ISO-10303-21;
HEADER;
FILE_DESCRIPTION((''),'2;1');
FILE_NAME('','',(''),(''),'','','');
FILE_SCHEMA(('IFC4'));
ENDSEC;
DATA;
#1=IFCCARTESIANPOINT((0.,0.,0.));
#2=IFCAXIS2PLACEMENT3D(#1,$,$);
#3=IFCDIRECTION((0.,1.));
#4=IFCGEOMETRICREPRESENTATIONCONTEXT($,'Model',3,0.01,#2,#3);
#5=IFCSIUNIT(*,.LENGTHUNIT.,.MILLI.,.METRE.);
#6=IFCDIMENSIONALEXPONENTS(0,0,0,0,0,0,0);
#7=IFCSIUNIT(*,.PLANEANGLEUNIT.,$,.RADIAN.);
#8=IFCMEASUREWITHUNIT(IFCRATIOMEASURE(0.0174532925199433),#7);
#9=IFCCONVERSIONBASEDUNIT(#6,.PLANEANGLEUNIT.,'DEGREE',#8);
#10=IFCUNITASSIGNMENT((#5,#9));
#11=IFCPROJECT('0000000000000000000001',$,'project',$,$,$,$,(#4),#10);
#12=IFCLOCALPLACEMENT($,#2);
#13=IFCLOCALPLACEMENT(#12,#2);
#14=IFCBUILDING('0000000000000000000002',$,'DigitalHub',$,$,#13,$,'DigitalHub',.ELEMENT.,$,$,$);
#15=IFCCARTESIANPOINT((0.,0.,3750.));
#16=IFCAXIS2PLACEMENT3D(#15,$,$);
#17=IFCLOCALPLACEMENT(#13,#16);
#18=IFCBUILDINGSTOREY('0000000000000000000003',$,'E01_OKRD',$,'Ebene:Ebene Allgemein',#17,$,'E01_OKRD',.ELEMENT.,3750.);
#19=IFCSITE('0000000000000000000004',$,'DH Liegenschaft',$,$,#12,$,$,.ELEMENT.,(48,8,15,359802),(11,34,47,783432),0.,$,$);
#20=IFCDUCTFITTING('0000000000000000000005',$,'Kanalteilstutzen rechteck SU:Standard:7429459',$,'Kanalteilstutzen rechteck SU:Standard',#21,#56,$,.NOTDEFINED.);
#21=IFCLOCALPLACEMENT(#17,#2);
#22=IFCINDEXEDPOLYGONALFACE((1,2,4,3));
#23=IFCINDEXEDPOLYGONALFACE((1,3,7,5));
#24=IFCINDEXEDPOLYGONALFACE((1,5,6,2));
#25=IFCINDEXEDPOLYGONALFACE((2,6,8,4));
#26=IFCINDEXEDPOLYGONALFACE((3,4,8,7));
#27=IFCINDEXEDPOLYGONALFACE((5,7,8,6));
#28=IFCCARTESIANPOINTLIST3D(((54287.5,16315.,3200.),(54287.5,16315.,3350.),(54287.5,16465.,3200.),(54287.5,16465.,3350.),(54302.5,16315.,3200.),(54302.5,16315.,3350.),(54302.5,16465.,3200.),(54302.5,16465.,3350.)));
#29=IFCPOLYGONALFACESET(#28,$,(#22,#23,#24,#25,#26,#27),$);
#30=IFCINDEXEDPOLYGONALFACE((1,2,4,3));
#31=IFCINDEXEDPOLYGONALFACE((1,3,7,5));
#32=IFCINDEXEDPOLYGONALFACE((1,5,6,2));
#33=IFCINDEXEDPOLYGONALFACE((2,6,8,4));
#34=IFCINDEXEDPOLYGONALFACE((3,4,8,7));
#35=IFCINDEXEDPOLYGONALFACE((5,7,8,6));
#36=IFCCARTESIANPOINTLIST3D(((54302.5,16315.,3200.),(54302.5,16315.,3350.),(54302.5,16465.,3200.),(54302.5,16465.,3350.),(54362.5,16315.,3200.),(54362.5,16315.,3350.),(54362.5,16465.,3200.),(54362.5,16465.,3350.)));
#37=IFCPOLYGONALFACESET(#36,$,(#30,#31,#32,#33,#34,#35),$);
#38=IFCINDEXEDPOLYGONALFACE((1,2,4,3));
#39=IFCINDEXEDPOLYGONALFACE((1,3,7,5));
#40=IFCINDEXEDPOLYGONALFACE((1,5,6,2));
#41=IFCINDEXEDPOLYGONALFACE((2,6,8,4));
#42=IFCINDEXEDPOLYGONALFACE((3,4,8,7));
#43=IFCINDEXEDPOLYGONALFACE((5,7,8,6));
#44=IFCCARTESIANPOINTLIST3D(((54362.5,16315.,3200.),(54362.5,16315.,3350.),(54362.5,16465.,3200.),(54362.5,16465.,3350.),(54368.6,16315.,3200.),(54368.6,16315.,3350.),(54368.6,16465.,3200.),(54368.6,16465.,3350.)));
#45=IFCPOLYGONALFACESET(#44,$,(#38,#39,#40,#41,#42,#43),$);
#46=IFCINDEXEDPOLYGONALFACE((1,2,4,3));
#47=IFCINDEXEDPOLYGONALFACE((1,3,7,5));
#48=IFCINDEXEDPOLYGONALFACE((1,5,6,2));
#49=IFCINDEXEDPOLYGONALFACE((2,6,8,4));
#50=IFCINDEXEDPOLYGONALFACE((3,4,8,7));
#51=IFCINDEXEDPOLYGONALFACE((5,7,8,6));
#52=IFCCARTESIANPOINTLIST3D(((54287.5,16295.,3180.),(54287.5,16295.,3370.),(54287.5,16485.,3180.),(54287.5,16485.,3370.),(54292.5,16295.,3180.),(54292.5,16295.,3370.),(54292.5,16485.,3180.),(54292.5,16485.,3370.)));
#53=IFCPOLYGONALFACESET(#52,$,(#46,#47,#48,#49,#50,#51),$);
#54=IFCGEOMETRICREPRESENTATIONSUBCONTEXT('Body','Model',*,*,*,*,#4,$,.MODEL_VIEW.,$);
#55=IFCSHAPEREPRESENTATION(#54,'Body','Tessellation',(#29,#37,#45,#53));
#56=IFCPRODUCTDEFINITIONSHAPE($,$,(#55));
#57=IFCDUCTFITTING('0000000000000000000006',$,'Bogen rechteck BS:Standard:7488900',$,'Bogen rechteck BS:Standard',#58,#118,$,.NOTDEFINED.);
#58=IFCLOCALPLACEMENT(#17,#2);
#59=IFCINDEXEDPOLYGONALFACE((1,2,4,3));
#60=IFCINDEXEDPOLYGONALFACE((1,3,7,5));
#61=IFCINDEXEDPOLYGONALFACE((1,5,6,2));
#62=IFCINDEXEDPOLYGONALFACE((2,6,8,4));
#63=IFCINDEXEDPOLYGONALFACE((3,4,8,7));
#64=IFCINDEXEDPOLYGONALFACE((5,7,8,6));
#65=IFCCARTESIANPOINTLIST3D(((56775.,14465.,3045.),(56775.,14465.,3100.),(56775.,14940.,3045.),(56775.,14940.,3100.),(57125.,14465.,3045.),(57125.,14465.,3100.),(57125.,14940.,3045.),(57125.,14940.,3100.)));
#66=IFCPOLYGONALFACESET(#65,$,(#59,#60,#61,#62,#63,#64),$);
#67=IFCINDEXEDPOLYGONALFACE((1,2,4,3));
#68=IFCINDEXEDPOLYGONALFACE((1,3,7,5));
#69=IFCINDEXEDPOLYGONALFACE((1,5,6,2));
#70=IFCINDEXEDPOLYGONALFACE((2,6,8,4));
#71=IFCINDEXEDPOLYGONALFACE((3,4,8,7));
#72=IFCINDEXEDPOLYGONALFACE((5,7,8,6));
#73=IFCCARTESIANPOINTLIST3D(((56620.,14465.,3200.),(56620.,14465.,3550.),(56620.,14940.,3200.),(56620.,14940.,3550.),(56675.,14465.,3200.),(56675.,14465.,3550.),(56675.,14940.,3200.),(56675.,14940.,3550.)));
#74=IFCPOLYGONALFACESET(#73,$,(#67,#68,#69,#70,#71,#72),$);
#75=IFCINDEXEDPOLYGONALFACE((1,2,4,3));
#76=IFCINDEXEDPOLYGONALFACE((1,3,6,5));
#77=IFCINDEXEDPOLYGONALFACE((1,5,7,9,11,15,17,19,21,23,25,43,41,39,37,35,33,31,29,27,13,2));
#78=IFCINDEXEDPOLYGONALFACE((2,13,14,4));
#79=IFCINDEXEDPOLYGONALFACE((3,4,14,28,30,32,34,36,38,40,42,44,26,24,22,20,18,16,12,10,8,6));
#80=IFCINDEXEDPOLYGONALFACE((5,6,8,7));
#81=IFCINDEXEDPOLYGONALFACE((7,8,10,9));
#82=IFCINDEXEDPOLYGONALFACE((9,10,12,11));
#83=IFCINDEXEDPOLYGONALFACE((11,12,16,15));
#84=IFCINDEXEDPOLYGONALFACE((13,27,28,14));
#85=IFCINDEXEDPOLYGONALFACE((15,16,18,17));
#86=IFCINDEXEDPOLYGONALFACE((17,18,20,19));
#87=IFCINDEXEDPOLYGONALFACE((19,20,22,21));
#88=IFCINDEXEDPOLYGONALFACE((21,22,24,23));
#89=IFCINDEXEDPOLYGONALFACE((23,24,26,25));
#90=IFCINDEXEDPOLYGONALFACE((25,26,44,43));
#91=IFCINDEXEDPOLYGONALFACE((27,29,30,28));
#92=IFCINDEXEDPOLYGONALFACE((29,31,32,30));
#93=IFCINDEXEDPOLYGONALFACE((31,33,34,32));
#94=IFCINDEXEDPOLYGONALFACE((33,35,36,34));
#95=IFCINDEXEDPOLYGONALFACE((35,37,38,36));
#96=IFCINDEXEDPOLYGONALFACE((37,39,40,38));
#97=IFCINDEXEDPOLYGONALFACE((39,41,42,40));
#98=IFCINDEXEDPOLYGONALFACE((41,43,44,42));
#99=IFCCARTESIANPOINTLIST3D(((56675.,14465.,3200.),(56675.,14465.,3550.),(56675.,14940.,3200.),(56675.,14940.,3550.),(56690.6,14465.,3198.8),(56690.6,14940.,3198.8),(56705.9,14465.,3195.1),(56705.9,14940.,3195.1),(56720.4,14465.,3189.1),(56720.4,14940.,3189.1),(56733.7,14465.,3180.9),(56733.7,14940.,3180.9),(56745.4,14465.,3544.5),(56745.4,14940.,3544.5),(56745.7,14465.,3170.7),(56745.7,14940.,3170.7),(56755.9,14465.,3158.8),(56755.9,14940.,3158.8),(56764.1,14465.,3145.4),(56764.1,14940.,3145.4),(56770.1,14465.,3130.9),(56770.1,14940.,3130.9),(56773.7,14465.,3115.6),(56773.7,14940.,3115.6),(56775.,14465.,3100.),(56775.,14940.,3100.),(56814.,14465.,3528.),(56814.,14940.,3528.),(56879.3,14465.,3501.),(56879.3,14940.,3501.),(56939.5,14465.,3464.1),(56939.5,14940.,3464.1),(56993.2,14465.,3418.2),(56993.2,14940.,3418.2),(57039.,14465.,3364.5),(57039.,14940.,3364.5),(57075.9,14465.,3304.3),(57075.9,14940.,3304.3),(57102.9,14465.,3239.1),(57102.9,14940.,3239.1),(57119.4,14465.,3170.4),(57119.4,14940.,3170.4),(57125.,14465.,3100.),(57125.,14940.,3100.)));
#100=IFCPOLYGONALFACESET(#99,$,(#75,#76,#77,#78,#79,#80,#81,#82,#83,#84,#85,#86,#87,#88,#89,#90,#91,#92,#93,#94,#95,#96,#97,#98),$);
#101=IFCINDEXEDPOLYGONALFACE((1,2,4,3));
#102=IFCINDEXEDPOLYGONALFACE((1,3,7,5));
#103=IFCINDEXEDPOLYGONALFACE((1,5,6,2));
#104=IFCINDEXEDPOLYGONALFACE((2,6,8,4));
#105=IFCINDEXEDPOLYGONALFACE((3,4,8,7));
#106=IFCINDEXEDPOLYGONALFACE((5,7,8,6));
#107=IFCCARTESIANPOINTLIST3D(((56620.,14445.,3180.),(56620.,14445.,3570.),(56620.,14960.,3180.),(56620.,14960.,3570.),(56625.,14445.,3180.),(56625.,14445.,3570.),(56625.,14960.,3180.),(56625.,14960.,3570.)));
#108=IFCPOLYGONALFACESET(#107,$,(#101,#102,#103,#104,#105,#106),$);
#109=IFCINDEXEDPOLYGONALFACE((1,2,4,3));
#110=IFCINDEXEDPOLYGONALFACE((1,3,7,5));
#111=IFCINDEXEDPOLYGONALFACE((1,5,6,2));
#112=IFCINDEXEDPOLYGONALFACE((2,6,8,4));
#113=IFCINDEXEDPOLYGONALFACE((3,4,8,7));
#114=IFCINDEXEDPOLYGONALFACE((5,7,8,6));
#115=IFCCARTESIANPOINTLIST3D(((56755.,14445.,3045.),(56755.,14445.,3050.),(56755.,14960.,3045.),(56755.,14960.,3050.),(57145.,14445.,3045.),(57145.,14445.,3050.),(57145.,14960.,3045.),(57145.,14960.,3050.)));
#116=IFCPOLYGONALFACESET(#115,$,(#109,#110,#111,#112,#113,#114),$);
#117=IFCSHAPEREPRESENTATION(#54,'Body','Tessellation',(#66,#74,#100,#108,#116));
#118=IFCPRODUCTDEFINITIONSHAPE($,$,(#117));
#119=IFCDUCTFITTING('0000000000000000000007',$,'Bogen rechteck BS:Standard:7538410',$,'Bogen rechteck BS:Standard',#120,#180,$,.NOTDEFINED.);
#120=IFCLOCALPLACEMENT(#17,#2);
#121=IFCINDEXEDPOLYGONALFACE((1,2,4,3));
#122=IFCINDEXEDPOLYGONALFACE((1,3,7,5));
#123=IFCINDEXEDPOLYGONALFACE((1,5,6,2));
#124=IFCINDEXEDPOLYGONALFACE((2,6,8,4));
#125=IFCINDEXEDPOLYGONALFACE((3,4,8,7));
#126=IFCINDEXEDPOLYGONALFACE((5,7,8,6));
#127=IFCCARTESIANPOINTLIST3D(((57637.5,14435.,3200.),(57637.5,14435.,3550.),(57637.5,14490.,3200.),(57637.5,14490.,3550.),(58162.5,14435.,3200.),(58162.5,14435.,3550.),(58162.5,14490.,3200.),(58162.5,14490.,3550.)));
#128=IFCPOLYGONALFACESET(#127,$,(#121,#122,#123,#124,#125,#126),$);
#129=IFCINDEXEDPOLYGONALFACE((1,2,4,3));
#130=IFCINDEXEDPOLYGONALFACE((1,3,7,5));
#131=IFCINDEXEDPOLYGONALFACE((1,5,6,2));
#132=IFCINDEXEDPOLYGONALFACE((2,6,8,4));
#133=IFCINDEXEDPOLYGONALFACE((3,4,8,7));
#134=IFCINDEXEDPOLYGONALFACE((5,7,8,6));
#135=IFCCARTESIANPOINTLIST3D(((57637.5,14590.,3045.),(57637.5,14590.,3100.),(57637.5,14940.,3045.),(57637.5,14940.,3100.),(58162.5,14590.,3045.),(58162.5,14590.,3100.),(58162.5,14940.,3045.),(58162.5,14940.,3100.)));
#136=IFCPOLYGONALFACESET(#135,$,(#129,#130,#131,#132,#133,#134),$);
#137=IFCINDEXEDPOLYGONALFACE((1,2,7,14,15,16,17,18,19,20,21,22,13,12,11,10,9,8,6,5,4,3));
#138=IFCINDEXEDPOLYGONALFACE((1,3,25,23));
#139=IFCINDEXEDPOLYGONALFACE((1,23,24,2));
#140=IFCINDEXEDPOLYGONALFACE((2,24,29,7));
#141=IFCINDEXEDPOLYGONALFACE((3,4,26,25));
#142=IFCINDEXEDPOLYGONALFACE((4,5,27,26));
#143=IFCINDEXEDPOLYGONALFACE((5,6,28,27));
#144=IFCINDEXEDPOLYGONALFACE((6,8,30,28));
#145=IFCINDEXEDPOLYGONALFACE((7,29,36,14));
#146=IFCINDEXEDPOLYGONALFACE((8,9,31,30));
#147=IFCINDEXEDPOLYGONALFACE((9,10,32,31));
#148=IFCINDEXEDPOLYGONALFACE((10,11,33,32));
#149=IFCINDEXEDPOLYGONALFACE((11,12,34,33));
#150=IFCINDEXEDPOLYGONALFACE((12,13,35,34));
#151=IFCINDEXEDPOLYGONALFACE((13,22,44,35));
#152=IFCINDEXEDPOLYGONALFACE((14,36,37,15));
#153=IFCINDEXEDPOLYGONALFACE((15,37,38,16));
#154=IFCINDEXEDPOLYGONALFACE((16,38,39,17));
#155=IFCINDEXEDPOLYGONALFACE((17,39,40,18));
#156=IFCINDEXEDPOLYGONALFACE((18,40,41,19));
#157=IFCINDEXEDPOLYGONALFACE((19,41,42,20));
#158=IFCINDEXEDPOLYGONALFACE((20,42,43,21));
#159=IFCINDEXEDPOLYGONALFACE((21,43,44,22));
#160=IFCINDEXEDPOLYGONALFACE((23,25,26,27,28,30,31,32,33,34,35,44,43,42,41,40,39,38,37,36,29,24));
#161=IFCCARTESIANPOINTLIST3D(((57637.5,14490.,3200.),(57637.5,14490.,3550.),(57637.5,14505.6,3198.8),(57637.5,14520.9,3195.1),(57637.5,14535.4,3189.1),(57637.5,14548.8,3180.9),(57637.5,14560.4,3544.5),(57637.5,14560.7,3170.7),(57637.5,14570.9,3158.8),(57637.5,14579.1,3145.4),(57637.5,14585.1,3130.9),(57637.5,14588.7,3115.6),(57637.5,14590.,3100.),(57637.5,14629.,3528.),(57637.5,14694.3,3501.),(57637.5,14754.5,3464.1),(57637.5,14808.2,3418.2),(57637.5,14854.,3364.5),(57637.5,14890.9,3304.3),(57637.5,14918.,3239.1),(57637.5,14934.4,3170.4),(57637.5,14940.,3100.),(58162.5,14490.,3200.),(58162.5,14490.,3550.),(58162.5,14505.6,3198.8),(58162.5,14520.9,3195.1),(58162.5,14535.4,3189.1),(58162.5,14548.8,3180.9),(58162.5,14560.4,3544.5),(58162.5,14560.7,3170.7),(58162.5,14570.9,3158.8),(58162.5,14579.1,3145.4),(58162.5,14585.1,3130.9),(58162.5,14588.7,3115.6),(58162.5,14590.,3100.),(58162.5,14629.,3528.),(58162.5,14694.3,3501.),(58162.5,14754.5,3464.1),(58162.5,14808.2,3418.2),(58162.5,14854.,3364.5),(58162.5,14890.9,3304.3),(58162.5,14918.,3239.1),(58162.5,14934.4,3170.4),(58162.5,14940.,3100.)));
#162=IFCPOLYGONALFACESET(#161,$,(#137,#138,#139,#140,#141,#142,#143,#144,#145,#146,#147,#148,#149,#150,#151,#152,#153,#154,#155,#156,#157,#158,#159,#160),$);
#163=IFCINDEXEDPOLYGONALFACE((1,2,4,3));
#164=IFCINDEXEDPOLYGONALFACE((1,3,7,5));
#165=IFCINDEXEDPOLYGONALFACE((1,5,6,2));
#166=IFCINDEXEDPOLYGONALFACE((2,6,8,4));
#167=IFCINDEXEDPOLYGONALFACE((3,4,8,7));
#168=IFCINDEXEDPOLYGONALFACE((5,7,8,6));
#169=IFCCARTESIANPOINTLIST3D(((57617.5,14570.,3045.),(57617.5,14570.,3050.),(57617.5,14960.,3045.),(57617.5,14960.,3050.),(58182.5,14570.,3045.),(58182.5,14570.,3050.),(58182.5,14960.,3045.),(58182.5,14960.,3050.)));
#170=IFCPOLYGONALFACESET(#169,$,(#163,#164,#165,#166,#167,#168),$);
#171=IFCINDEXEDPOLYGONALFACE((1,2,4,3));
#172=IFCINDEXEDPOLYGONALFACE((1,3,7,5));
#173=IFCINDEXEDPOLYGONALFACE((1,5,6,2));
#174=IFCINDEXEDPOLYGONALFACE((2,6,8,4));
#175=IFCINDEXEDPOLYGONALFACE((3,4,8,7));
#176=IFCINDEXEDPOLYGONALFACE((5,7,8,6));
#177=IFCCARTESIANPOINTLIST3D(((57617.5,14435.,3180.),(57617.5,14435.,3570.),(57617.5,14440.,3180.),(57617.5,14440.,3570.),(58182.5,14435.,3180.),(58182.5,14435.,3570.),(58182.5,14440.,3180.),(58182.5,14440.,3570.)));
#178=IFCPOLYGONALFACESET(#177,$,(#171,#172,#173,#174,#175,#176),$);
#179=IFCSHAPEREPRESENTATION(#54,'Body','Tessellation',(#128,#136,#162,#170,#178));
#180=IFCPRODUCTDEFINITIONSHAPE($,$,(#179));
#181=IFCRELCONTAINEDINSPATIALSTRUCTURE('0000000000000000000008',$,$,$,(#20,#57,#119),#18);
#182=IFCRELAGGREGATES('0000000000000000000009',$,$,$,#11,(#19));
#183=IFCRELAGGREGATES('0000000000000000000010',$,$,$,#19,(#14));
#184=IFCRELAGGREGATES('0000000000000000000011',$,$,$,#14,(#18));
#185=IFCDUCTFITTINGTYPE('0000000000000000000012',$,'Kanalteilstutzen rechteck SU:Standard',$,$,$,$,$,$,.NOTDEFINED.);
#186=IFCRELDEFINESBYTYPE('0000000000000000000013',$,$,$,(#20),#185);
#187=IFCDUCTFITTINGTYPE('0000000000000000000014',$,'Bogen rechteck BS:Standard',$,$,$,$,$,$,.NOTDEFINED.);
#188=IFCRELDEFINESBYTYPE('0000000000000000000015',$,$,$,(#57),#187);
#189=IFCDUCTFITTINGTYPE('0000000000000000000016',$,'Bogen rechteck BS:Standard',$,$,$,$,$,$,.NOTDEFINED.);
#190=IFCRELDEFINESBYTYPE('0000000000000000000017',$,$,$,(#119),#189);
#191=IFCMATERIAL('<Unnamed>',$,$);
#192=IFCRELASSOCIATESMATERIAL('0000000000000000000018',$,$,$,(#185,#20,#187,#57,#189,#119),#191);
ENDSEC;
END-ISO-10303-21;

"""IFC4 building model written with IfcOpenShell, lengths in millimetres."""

from ifc_helpers import new_model, entity, si_unit, converted_unit, direction, frame, origin, place, context, subcontext, project, spatial, indexed_curve, outline, extrude, source, transform, mapped, material, type_object, type_shapes, element, save


model = new_model("IFC4")

# Units and contexts
model_context = context("Model", 3, precision=0.01, world=origin(), true_north=direction((0.0, 1.0)))
body_context = subcontext(model_context, "Body", "Model", "MODEL_VIEW")
ifc_project = project(units=[si_unit("LENGTHUNIT", "METRE", prefix="MILLI"), converted_unit("PLANEANGLEUNIT", "DEGREE", entity("IfcRatioMeasure", 0.0174532925199433), si_unit("PLANEANGLEUNIT", "RADIAN"), dimensions=[0, 0, 0, 0, 0, 0, 0])], contexts=[model_context])

# Site, building, storey
site_placement = place(None, origin())
site = spatial("IfcSite", under=ifc_project, at=site_placement, Name="DH Liegenschaft", CompositionType="ELEMENT", RefLatitude=(48, 8, 15, 359802), RefLongitude=(11, 34, 47, 783432), RefElevation=0.0)
building_placement = place(site_placement, origin())
building = spatial("IfcBuilding", under=site, at=building_placement, Name="DigitalHub", LongName="DigitalHub", CompositionType="ELEMENT")
storey_placement = place(building_placement, frame((0.0, 0.0, 3750.0)))
storey = spatial("IfcBuildingStorey", under=building, at=storey_placement, Name="E01_OKRD", ObjectType="Ebene:Ebene Allgemein", LongName="E01_OKRD", CompositionType="ELEMENT", Elevation=3750.0)

# Shared definitions
ifc_material_1 = material(Name="<Unnamed>")

# Duct fittings
duct_fitting_type_1 = type_object("IfcDuctFittingType", Name="Kanalteilstutzen rechteck SU:Standard", PredefinedType="NOTDEFINED", material=ifc_material_1)
shared_shape_1 = source(origin(), body_context, "Body", "SweptSolid", [
    extrude(outline(indexed_curve([(-7.5, -75.0), (7.5, -75.0), (7.5, 75.0), (-7.5, 75.0), (-7.5, -75.0)], self_intersect=False)), frame((67.5, 0.0, -75.0)), (0.0, 0.0, 1.0), 150.0),
    extrude(outline(indexed_curve([(-30.0, -75.0), (30.0, -75.0), (30.0, 75.0), (-30.0, 75.0), (-30.0, -75.0)], self_intersect=False)), frame((30.0, 0.0, -75.0)), (0.0, 0.0, 1.0), 150.0),
    extrude(outline(indexed_curve([(-3.0, -75.0), (3.0, -75.0), (3.0, 75.0), (-3.0, 75.0), (-3.0, -75.0)], self_intersect=False)), frame((-3.0, 0.0, -75.0)), (0.0, 0.0, 1.0), 150.0),
    extrude(outline(indexed_curve([(-2.5, -95.0), (2.5, -95.0), (2.5, 95.0), (-2.5, 95.0), (-2.5, -95.0)], self_intersect=False)), frame((72.5, 0.0, -95.0)), (0.0, 0.0, 1.0), 190.0),
])
type_shapes(duct_fitting_type_1, [shared_shape_1])
duct_fitting_1_placement = place(storey_placement, frame((54362.5, 16390.0, 3275.0), z_axis=(0.000013, 0.0, -1.0), x_axis=(-1.0, 0.0, -0.000013)))
element("IfcDuctFitting", 1, at=duct_fitting_1_placement, inside=storey, type_object=duct_fitting_type_1, material=ifc_material_1, Name="Kanalteilstutzen rechteck SU:Standard:7429459", ObjectType="Kanalteilstutzen rechteck SU:Standard", PredefinedType="NOTDEFINED", context=body_context, shape_type="MappedRepresentation", body=[
    mapped(shared_shape_1, transform((0.0, 0.0, 0.0), scale=1.0)),
])
duct_fitting_type_2 = type_object("IfcDuctFittingType", Name="Bogen rechteck BS:Standard", PredefinedType="NOTDEFINED", material=ifc_material_1)
shared_shape_2 = source(origin(), body_context, "Body", "SweptSolid", [
    extrude(outline(indexed_curve([(-27.5, -175.0), (27.5, -175.0), (27.5, 175.0), (-27.5, 175.0), (-27.5, -175.0)], self_intersect=False)), frame((0.0, 302.5, -237.5), z_axis=(0.0, 0.0, 1.0), x_axis=(0.0, 1.0, 0.0)), (0.0, 0.0, 1.0), 475.0),
    extrude(outline(indexed_curve([(-175.0, -27.5), (175.0, -27.5), (175.0, 27.5), (-175.0, 27.5), (-175.0, -27.5)], self_intersect=False)), frame((-302.5, 0.0, -237.5), z_axis=(0.0, 0.0, 1.0), x_axis=(0.0, -1.0, 0.0)), (0.0, 0.0, 1.0), 475.0),
    extrude(outline(indexed_curve([(-312.5, -137.5), (37.5, -137.5), (38.7, -121.9), (42.4, -106.6), (48.4, -92.1), (56.6, -78.7), (66.8, -66.8), (78.7, -56.6), (92.1, -48.4), (106.6, -42.4), (121.9, -38.7), (137.5, -37.5), (137.5, 312.5), (67.1, 307.0), (-1.6, 290.5), (-66.8, 263.5), (-127.0, 226.6), (-180.7, 180.7), (-226.6, 127.0), (-263.5, 66.8), (-290.5, 1.6), (-307.0, -67.1), (-312.5, -137.5)], self_intersect=False)), frame((-137.5, 137.5, -237.5), z_axis=(0.0, 0.0, 1.0), x_axis=(-1.0, 0.0, 0.0)), (0.0, 0.0, 1.0), 475.0),
    extrude(outline(indexed_curve([(-2.5, -195.0), (2.5, -195.0), (2.5, 195.0), (-2.5, 195.0), (-2.5, -195.0)], self_intersect=False)), frame((-327.5, 0.0, -257.5)), (0.0, 0.0, 1.0), 515.0),
    extrude(outline(indexed_curve([(-2.5, -195.0), (2.5, -195.0), (2.5, 195.0), (-2.5, 195.0), (-2.5, -195.0)], self_intersect=False)), frame((0.0, 327.5, -257.5), z_axis=(0.0, 0.0, 1.0), x_axis=(0.0, 1.0, 0.0)), (0.0, 0.0, 1.0), 515.0),
])
type_shapes(duct_fitting_type_2, [shared_shape_2])
duct_fitting_2_placement = place(storey_placement, frame((56950.0, 14702.5, 3375.0), z_axis=(0.0, 1.0, 0.0), x_axis=(1.0, 0.0, 0.0)))
element("IfcDuctFitting", 2, at=duct_fitting_2_placement, inside=storey, type_object=duct_fitting_type_2, material=ifc_material_1, Name="Bogen rechteck BS:Standard:7488900", ObjectType="Bogen rechteck BS:Standard", PredefinedType="NOTDEFINED", context=body_context, shape_type="MappedRepresentation", body=[
    mapped(shared_shape_2, transform((0.0, 0.0, 0.0), scale=1.0)),
])
duct_fitting_type_3 = type_object("IfcDuctFittingType", Name="Bogen rechteck BS:Standard", PredefinedType="NOTDEFINED", material=ifc_material_1)
shared_shape_3 = source(origin(), body_context, "Body", "SweptSolid", [
    extrude(outline(indexed_curve([(-27.5, -175.0), (27.5, -175.0), (27.5, 175.0), (-27.5, 175.0), (-27.5, -175.0)], self_intersect=False)), frame((0.0, 302.5, -262.5), z_axis=(0.0, 0.0, 1.0), x_axis=(0.0, 1.0, 0.0)), (0.0, 0.0, 1.0), 525.0),
    extrude(outline(indexed_curve([(-175.0, -27.5), (175.0, -27.5), (175.0, 27.5), (-175.0, 27.5), (-175.0, -27.5)], self_intersect=False)), frame((-302.5, 0.0, -262.5), z_axis=(0.0, 0.0, 1.0), x_axis=(0.0, -1.0, 0.0)), (0.0, 0.0, 1.0), 525.0),
    extrude(outline(indexed_curve([(-312.5, -137.5), (37.5, -137.5), (38.7, -121.9), (42.4, -106.6), (48.4, -92.1), (56.6, -78.7), (66.8, -66.8), (78.7, -56.6), (92.1, -48.4), (106.6, -42.4), (121.9, -38.7), (137.5, -37.5), (137.5, 312.5), (67.1, 307.0), (-1.6, 290.5), (-66.8, 263.5), (-127.0, 226.6), (-180.7, 180.7), (-226.6, 127.0), (-263.5, 66.8), (-290.5, 1.6), (-307.0, -67.1), (-312.5, -137.5)], self_intersect=False)), frame((-137.5, 137.5, -262.5), z_axis=(0.0, 0.0, 1.0), x_axis=(-1.0, 0.0, 0.0)), (0.0, 0.0, 1.0), 525.0),
    extrude(outline(indexed_curve([(-2.5, -195.0), (2.5, -195.0), (2.5, 195.0), (-2.5, 195.0), (-2.5, -195.0)], self_intersect=False)), frame((-327.5, 0.0, -282.5)), (0.0, 0.0, 1.0), 565.0),
    extrude(outline(indexed_curve([(-2.5, -195.0), (2.5, -195.0), (2.5, 195.0), (-2.5, 195.0), (-2.5, -195.0)], self_intersect=False)), frame((0.0, 327.5, -282.5), z_axis=(0.0, 0.0, 1.0), x_axis=(0.0, 1.0, 0.0)), (0.0, 0.0, 1.0), 565.0),
])
type_shapes(duct_fitting_type_3, [shared_shape_3])
duct_fitting_3_placement = place(storey_placement, frame((57900.0, 14765.0, 3375.0), z_axis=(1.0, 0.0, 0.0), x_axis=(0.0, 0.0, 1.0)))
element("IfcDuctFitting", 3, at=duct_fitting_3_placement, inside=storey, type_object=duct_fitting_type_3, material=ifc_material_1, Name="Bogen rechteck BS:Standard:7538410", ObjectType="Bogen rechteck BS:Standard", PredefinedType="NOTDEFINED", context=body_context, shape_type="MappedRepresentation", body=[
    mapped(shared_shape_3, transform((0.0, 0.0, 0.0), scale=1.0)),
])

save(model, "model.ifc")
